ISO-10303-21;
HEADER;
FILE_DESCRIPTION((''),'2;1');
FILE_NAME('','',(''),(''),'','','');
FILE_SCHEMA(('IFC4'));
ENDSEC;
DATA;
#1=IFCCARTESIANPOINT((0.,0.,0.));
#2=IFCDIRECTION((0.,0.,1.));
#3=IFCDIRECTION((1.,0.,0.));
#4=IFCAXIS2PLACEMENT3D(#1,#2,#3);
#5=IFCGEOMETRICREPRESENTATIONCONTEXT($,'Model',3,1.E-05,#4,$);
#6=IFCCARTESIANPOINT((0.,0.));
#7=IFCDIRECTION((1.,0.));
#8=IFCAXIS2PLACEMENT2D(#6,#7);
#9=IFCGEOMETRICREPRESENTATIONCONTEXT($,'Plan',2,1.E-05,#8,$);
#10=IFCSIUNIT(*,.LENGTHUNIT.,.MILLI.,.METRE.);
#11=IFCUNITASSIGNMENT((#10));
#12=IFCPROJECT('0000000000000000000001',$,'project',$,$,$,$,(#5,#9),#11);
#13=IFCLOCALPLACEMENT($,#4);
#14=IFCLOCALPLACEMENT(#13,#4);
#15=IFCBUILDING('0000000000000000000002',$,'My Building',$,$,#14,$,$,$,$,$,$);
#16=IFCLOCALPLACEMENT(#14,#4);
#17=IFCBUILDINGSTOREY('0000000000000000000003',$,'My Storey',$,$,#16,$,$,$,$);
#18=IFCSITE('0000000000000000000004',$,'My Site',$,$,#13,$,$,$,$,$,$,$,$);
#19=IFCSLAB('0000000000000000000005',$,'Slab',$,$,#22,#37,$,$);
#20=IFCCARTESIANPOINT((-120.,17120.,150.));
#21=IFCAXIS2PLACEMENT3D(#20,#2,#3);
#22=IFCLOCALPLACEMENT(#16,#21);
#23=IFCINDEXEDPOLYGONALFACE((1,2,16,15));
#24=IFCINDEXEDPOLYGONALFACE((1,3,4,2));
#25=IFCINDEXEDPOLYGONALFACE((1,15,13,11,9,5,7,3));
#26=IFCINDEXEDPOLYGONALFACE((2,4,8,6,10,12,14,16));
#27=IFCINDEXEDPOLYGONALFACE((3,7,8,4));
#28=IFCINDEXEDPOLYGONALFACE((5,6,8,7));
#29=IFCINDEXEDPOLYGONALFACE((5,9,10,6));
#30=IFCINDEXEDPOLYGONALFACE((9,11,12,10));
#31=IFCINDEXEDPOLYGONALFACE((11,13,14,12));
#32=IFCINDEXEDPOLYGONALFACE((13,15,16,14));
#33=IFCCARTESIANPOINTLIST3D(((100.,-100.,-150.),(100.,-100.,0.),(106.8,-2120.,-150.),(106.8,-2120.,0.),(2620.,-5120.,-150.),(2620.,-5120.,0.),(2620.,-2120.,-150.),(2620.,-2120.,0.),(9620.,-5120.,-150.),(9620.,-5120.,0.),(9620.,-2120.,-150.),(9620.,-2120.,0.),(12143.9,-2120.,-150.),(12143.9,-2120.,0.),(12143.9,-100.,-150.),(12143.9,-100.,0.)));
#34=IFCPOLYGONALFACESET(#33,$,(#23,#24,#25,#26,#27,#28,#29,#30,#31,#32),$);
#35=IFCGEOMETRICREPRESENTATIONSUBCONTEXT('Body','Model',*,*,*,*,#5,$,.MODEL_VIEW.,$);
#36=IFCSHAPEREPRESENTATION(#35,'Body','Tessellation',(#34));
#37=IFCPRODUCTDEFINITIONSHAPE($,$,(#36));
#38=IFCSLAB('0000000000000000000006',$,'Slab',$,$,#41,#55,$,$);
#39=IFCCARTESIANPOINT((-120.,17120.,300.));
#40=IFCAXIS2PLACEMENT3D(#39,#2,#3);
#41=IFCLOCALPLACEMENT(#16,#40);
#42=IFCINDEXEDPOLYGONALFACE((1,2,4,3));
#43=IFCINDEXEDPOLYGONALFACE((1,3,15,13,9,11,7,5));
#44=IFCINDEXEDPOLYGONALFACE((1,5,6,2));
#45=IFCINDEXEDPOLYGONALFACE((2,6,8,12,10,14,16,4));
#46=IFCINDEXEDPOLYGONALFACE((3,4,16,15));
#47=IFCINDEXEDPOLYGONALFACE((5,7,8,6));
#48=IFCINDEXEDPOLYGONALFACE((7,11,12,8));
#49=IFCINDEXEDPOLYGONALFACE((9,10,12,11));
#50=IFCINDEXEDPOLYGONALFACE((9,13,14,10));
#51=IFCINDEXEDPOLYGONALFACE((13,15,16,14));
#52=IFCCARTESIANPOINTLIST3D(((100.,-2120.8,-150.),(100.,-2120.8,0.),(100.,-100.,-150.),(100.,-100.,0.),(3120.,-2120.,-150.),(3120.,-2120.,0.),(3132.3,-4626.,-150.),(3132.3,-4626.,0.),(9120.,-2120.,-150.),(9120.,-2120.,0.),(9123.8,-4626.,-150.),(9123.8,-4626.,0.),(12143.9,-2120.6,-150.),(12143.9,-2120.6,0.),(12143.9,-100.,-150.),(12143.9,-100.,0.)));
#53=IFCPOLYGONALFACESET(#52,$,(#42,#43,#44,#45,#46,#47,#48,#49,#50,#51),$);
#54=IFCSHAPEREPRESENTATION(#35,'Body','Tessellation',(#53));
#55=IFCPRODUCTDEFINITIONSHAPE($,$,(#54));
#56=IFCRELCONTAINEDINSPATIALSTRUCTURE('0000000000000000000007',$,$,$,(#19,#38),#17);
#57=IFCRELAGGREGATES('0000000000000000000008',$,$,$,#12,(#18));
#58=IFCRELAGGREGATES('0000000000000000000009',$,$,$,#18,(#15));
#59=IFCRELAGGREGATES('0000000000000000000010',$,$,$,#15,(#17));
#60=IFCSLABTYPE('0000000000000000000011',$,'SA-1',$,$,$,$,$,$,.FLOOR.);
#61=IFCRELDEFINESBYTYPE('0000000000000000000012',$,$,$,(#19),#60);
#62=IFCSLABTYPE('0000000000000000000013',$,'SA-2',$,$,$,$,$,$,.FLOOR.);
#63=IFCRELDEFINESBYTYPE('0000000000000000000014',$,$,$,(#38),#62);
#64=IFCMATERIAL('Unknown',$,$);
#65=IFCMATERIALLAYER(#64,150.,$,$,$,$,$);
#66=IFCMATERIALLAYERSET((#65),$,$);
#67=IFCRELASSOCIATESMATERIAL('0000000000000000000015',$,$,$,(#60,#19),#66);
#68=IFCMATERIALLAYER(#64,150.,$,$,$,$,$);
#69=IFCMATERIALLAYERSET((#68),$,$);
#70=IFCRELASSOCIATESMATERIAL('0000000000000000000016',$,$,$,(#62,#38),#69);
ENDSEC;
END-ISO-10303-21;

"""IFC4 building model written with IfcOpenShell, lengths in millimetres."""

from ifc_helpers import new_model, si_unit, frame, origin_with_axes, origin_2d_with_axis, place, context, subcontext, project, spatial, indexed_curve, outline, extrude, material, layer, layer_set, layer_usage, type_object, element, save


model = new_model("IFC4")

# Units and contexts
model_context = context("Model", 3, precision=1e-05, world=origin_with_axes())
plan_context = context("Plan", 2, precision=1e-05, world=origin_2d_with_axis())
body_context_1 = subcontext(model_context, "Body", "Model", "MODEL_VIEW")
ifc_project = project(units=[si_unit("LENGTHUNIT", "METRE", prefix="MILLI")], contexts=[model_context, plan_context])

# Site, building, storey
site_placement = place(None, origin_with_axes())
site = spatial("IfcSite", under=ifc_project, at=site_placement, Name="My Site")
building_placement = place(site_placement, origin_with_axes())
building = spatial("IfcBuilding", under=site, at=building_placement, Name="My Building")
storey_placement = place(building_placement, origin_with_axes())
storey = spatial("IfcBuildingStorey", under=building, at=storey_placement, Name="My Storey")

# Shared definitions
ifc_material = material(Name="Unknown")

# Slabs
ifc_layer_1 = layer(ifc_material, 150.0)
ifc_layer_set_1 = layer_set([ifc_layer_1])
ifc_layer_usage_1 = layer_usage(ifc_layer_set_1, "AXIS3", "POSITIVE", -150.0)
slab_type_1 = type_object("IfcSlabType", Name="SA-1", PredefinedType="FLOOR", material=ifc_layer_set_1)
slab_1_placement = place(storey_placement, frame((-120.0, 17120.0, 150.0), z_axis=(0.0, 0.0, 1.0), x_axis=(1.0, 0.0, 0.0)))
element("IfcSlab", 1, at=slab_1_placement, inside=storey, type_object=slab_type_1, material=ifc_layer_usage_1, Name="Slab", context=body_context_1, shape_type="SweptSolid", body=[
    extrude(outline(indexed_curve([(100.0, -100.0), (12143.9, -100.0), (12143.9, -2120.0), (9620.0, -2120.0), (9620.0, -5120.0), (2620.0, -5120.0), (2620.0, -2120.0), (106.8, -2120.0), (100.0, -100.0)])), frame((0.0, 0.0, -150.0), z_axis=(0.0, 0.0, 1.0), x_axis=(1.0, 0.0, 0.0)), (0.0, 0.0, 1.0), 150.0),
])
ifc_layer_2 = layer(ifc_material, 150.0)
ifc_layer_set_2 = layer_set([ifc_layer_2])
ifc_layer_usage_2 = layer_usage(ifc_layer_set_2, "AXIS3", "POSITIVE", -150.0)
slab_type_2 = type_object("IfcSlabType", Name="SA-2", PredefinedType="FLOOR", material=ifc_layer_set_2)
slab_2_placement = place(storey_placement, frame((-120.0, 17120.0, 300.0), z_axis=(0.0, 0.0, 1.0), x_axis=(1.0, 0.0, 0.0)))
element("IfcSlab", 2, at=slab_2_placement, inside=storey, type_object=slab_type_2, material=ifc_layer_usage_2, Name="Slab", context=body_context_1, shape_type="SweptSolid", body=[
    extrude(outline(indexed_curve([(100.0, -2120.8), (3120.0, -2120.0), (3132.3, -4626.0), (9123.8, -4626.0), (9120.0, -2120.0), (12143.9, -2120.6), (12143.9, -100.0), (100.0, -100.0), (100.0, -2120.8)])), frame((0.0, 0.0, -150.0), z_axis=(0.0, 0.0, 1.0), x_axis=(1.0, 0.0, 0.0)), (0.0, 0.0, 1.0), 150.0),
])

save(model, "model.ifc")
